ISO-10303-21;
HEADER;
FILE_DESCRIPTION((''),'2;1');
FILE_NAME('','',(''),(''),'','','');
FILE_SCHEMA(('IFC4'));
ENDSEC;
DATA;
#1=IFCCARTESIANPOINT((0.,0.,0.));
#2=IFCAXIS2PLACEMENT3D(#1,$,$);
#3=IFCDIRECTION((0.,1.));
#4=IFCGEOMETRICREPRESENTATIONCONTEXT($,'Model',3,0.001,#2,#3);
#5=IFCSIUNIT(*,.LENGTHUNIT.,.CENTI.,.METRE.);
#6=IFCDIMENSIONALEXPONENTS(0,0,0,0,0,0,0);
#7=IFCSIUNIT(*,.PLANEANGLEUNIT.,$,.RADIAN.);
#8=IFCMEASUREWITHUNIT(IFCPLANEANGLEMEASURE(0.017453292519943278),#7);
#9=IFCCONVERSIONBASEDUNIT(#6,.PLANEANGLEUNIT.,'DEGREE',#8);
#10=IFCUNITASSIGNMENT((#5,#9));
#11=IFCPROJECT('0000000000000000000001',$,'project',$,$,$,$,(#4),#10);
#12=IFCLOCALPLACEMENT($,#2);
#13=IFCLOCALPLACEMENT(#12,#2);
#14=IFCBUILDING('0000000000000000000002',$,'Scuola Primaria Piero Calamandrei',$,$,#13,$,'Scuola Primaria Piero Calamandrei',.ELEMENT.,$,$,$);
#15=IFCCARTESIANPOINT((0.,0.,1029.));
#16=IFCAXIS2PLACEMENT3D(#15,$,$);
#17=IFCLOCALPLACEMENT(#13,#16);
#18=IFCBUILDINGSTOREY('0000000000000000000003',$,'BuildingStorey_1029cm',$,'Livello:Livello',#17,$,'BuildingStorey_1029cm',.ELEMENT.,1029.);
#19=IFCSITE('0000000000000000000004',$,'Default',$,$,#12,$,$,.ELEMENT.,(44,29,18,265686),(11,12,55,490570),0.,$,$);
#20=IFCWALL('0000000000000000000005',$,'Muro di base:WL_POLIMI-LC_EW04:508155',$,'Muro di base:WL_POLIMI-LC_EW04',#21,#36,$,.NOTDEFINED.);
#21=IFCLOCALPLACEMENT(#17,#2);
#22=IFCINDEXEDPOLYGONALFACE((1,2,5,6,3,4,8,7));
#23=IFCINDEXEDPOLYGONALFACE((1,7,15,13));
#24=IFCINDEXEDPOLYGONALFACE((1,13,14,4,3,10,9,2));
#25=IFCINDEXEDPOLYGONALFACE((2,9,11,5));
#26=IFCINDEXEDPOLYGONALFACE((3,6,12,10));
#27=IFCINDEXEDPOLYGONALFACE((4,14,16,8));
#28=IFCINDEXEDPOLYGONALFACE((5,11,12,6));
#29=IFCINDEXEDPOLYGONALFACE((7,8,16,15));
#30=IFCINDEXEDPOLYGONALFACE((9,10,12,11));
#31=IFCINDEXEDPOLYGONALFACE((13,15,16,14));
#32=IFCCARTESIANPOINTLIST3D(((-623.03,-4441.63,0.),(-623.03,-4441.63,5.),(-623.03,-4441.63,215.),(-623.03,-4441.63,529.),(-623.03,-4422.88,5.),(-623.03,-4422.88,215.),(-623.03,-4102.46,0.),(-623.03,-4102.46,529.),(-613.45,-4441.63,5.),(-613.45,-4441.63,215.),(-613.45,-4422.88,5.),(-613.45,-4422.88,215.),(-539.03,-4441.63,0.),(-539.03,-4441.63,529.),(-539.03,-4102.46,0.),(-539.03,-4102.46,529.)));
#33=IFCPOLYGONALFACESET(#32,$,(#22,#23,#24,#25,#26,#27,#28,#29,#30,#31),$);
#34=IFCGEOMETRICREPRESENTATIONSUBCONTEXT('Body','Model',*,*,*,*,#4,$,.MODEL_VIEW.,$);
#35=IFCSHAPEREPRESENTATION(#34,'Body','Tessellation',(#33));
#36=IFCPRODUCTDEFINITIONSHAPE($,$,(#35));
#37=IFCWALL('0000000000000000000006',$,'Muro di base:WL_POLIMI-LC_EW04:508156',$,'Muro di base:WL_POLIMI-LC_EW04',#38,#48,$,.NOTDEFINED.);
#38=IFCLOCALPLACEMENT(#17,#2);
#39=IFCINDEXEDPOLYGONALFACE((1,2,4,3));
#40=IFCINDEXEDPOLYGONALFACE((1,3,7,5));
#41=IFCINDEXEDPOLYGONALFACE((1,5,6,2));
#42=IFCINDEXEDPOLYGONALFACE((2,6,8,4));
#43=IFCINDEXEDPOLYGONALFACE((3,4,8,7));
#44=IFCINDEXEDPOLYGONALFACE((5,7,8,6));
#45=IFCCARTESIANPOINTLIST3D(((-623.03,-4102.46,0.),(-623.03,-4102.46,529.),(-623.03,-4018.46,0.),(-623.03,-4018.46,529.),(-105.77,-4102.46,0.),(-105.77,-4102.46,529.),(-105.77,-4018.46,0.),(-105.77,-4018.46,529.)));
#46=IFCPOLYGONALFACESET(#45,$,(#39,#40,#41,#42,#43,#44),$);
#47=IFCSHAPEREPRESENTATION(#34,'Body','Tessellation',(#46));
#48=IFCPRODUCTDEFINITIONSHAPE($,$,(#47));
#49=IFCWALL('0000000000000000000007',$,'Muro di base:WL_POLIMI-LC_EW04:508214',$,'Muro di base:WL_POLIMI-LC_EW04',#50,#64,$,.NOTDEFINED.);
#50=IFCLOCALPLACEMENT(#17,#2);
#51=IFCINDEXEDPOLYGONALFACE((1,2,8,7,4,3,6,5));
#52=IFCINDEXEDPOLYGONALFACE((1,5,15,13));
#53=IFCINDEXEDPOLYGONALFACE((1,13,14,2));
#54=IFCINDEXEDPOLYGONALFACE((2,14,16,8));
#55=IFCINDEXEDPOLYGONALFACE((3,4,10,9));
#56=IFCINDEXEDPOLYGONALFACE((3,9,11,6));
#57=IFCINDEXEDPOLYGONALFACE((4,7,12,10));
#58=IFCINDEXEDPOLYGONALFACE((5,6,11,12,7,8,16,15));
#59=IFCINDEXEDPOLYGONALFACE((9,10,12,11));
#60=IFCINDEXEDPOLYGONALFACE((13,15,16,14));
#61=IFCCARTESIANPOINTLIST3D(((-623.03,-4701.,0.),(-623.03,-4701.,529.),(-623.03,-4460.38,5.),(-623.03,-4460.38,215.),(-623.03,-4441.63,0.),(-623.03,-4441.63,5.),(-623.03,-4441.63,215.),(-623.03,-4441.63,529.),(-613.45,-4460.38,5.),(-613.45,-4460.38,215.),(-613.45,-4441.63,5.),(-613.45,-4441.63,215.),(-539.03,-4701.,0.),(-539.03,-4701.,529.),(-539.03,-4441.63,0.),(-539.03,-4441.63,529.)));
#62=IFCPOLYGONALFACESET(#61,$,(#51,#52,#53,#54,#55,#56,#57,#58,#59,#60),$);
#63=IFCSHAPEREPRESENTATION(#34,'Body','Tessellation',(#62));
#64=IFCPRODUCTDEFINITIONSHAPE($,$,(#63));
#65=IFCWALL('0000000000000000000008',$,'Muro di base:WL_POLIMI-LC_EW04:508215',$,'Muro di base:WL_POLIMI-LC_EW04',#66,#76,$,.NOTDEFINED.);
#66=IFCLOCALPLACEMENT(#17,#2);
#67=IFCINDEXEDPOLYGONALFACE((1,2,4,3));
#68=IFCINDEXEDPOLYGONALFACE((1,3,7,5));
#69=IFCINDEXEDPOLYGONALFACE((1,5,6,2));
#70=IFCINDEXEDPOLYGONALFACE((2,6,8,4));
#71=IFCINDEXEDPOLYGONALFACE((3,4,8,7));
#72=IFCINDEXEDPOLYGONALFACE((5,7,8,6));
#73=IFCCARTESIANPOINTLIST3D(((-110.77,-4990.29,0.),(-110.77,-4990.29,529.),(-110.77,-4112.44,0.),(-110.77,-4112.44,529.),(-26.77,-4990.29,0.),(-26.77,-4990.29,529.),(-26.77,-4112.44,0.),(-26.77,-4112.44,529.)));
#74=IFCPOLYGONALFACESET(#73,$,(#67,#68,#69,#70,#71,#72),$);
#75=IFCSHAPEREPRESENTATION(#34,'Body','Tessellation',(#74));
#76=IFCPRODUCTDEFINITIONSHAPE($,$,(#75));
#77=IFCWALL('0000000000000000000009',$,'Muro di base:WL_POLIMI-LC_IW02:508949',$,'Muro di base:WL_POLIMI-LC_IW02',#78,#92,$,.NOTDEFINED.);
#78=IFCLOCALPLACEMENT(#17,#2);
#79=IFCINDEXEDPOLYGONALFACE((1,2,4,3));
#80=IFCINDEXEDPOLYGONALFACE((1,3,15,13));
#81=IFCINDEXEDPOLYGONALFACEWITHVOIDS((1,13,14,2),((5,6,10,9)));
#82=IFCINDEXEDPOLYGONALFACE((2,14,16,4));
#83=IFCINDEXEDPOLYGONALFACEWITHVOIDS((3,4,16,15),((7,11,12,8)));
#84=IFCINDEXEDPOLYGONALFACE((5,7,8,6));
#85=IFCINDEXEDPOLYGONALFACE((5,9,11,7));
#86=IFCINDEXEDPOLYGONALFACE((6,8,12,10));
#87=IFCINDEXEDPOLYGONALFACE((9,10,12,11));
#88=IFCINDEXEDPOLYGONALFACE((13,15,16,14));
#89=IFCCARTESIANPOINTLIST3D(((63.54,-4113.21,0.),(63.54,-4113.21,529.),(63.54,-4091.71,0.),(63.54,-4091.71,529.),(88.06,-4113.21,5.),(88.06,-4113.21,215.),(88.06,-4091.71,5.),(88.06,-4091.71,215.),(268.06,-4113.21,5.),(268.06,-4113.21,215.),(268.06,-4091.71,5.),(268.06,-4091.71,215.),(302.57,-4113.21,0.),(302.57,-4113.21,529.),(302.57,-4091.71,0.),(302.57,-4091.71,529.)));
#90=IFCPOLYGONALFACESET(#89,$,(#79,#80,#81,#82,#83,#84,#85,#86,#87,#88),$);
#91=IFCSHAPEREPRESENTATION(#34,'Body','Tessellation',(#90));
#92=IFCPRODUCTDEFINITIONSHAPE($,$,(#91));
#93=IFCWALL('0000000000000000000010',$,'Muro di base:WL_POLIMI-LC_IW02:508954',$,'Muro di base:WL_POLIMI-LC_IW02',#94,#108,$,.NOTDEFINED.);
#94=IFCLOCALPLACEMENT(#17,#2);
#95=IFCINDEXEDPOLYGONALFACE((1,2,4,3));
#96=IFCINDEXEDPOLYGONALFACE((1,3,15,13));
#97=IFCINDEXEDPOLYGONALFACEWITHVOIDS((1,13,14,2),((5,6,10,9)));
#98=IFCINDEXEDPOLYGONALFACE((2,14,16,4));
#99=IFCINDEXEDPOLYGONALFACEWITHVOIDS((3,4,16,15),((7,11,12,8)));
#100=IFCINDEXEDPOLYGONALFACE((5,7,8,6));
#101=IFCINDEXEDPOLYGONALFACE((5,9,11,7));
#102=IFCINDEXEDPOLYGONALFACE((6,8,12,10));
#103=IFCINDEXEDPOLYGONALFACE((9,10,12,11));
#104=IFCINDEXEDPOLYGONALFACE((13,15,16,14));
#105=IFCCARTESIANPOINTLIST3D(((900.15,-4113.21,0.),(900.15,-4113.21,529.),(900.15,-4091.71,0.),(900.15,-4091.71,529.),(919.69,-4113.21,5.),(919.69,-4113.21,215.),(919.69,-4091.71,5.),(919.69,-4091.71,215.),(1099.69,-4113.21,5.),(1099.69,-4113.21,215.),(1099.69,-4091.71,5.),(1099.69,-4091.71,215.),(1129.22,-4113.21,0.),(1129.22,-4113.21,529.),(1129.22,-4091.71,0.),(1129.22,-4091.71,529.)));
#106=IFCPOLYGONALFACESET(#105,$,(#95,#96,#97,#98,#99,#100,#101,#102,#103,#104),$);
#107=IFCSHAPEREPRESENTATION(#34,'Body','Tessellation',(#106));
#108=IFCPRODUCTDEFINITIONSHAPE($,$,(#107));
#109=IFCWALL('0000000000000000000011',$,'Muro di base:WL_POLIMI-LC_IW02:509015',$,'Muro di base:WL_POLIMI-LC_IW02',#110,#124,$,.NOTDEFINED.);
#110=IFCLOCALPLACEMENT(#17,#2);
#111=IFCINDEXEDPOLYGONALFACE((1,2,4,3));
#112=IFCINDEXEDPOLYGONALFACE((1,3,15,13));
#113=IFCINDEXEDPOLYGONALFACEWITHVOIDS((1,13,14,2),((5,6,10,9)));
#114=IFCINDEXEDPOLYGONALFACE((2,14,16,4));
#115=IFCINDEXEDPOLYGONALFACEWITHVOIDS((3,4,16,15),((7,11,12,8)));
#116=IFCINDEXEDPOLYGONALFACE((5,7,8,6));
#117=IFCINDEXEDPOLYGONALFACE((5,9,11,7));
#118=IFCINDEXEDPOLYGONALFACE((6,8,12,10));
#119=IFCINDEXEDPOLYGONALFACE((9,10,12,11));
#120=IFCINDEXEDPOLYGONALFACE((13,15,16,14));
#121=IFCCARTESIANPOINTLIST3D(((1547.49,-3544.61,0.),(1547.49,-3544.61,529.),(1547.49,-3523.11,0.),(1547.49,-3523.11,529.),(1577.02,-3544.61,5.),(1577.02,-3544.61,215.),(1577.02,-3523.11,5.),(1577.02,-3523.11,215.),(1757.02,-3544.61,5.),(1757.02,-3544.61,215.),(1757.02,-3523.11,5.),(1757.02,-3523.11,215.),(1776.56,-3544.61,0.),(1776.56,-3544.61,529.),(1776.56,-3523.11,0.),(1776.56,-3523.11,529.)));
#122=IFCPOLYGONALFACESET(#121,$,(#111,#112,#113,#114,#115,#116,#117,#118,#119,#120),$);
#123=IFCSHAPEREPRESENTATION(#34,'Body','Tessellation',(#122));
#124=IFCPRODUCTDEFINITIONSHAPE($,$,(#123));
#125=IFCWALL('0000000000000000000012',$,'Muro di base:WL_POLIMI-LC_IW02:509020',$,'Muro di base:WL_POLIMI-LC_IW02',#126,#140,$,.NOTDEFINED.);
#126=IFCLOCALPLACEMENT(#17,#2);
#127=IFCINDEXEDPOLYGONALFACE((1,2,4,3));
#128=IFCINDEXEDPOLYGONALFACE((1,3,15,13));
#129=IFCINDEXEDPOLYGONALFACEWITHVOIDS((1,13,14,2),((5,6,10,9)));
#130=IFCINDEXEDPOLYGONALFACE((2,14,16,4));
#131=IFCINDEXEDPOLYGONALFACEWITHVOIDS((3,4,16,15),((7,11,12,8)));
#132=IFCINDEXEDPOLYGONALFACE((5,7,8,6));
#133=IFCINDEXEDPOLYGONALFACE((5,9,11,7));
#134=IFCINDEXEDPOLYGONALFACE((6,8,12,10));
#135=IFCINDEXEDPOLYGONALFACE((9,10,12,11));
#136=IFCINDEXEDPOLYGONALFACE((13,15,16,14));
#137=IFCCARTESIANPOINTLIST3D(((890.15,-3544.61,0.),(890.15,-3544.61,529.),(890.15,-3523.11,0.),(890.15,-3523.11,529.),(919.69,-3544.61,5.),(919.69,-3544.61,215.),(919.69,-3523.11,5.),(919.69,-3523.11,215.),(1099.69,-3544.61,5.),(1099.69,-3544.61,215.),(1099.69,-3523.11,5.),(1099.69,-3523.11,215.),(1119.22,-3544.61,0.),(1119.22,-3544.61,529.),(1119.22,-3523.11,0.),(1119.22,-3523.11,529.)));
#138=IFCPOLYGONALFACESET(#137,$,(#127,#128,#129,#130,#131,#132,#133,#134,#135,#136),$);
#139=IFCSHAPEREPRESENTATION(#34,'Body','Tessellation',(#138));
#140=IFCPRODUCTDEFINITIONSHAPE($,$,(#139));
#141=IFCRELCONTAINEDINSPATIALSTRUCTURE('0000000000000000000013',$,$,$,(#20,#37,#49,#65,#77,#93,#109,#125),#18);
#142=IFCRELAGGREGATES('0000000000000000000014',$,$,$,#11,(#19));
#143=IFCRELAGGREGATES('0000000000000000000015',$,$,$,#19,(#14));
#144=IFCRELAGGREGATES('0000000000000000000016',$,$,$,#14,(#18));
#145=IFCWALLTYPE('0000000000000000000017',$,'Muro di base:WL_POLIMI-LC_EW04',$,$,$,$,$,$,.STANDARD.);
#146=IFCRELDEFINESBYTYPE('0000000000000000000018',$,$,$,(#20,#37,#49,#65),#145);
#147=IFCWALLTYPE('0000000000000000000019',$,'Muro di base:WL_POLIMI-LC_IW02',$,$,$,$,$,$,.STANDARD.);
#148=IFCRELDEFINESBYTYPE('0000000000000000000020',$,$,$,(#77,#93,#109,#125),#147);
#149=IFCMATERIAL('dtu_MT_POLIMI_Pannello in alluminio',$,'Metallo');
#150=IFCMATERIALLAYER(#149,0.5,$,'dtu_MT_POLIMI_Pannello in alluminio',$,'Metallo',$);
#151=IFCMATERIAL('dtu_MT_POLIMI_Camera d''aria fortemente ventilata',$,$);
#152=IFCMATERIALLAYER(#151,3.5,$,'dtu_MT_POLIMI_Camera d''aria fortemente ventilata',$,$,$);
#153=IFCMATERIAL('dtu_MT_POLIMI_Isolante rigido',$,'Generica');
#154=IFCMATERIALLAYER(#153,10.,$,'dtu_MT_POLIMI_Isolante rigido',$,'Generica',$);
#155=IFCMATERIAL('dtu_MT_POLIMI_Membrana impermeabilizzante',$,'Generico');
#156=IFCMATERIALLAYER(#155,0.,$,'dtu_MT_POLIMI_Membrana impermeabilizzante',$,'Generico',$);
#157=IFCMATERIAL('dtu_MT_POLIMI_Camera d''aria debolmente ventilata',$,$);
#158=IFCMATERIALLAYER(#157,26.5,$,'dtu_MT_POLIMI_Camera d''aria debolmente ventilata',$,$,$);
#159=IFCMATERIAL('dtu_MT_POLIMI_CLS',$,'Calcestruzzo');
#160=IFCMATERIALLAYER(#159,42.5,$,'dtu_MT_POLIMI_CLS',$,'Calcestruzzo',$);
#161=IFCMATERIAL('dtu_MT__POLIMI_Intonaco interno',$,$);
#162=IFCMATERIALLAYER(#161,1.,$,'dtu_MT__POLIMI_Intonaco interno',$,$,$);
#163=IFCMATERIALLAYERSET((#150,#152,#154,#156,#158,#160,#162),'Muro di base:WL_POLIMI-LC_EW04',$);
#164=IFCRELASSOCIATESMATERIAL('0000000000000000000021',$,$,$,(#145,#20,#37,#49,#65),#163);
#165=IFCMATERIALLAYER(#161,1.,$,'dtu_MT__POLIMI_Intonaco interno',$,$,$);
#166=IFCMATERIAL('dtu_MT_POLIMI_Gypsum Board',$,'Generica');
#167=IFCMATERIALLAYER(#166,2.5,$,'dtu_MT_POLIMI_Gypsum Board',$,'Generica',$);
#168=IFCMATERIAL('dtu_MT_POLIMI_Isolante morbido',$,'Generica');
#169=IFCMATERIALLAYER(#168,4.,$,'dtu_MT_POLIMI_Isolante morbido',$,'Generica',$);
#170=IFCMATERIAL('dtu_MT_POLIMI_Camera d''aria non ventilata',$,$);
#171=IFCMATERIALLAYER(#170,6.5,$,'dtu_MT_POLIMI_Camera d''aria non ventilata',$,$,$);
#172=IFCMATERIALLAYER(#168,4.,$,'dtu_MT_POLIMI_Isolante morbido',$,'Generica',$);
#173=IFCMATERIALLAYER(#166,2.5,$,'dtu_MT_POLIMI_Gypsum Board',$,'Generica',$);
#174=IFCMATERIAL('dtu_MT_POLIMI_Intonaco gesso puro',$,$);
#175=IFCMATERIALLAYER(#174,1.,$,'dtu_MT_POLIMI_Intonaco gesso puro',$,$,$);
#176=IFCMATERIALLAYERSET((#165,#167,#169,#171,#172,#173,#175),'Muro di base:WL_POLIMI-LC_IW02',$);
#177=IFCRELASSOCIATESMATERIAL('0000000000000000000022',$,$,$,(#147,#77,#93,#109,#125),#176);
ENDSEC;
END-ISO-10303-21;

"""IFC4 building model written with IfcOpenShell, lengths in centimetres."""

from ifc_helpers import new_model, entity, si_unit, converted_unit, direction, frame, frame_2d, origin, place, context, subcontext, project, spatial, rectangle, extrude, material, layer, layer_set, layer_usage, type_object, element, save


model = new_model("IFC4")

# Units and contexts
model_context = context("Model", 3, precision=0.001, world=origin(), true_north=direction((0.0, 1.0)))
body_context = subcontext(model_context, "Body", "Model", "MODEL_VIEW")
ifc_project = project(units=[si_unit("LENGTHUNIT", "METRE", prefix="CENTI"), converted_unit("PLANEANGLEUNIT", "DEGREE", entity("IfcPlaneAngleMeasure", 0.017453292519943278), si_unit("PLANEANGLEUNIT", "RADIAN"), dimensions=[0, 0, 0, 0, 0, 0, 0])], contexts=[model_context])

# Site, building, storey
site_placement = place(None, origin())
site = spatial("IfcSite", under=ifc_project, at=site_placement, Name="Default", CompositionType="ELEMENT", RefLatitude=(44, 29, 18, 265686), RefLongitude=(11, 12, 55, 490570), RefElevation=0.0)
building_placement = place(site_placement, origin())
building = spatial("IfcBuilding", under=site, at=building_placement, Name="Scuola Primaria Piero Calamandrei", LongName="Scuola Primaria Piero Calamandrei", CompositionType="ELEMENT")
storey_placement = place(building_placement, frame((0.0, 0.0, 1029.0)))
storey = spatial("IfcBuildingStorey", under=building, at=storey_placement, Name="BuildingStorey_1029cm", ObjectType="Livello:Livello", LongName="BuildingStorey_1029cm", CompositionType="ELEMENT", Elevation=1029.0)

# Wall, opening
ifc_material_1 = material(Name="dtu_MT_POLIMI_Pannello in alluminio", Category="Metallo")
ifc_layer_1 = layer(ifc_material_1, 0.5, Name="dtu_MT_POLIMI_Pannello in alluminio", Category="Metallo")
ifc_material_2 = material(Name="dtu_MT_POLIMI_Camera d'aria fortemente ventilata")
ifc_layer_2 = layer(ifc_material_2, 3.5, Name="dtu_MT_POLIMI_Camera d'aria fortemente ventilata")
ifc_material_3 = material(Name="dtu_MT_POLIMI_Isolante rigido", Category="Generica")
ifc_layer_3 = layer(ifc_material_3, 10.0, Name="dtu_MT_POLIMI_Isolante rigido", Category="Generica")
ifc_material_4 = material(Name="dtu_MT_POLIMI_Membrana impermeabilizzante", Category="Generico")
ifc_layer_4 = layer(ifc_material_4, 0.0, Name="dtu_MT_POLIMI_Membrana impermeabilizzante", Category="Generico")
ifc_material_5 = material(Name="dtu_MT_POLIMI_Camera d'aria debolmente ventilata")
ifc_layer_5 = layer(ifc_material_5, 26.5, Name="dtu_MT_POLIMI_Camera d'aria debolmente ventilata")
ifc_material_6 = material(Name="dtu_MT_POLIMI_CLS", Category="Calcestruzzo")
ifc_layer_6 = layer(ifc_material_6, 42.5, Name="dtu_MT_POLIMI_CLS", Category="Calcestruzzo")
ifc_material_7 = material(Name="dtu_MT__POLIMI_Intonaco interno")
ifc_layer_7 = layer(ifc_material_7, 1.0, Name="dtu_MT__POLIMI_Intonaco interno")
ifc_layer_set_1 = layer_set([ifc_layer_1, ifc_layer_2, ifc_layer_3, ifc_layer_4, ifc_layer_5, ifc_layer_6, ifc_layer_7], Name="Muro di base:WL_POLIMI-LC_EW04")
ifc_layer_usage_1 = layer_usage(ifc_layer_set_1, "AXIS2", "NEGATIVE", 42.0)
wall_type_1 = type_object("IfcWallType", Name="Muro di base:WL_POLIMI-LC_EW04", PredefinedType="STANDARD", material=ifc_layer_set_1)
wall_1_placement = place(storey_placement, frame((-581.03, -4102.46, 0.0), z_axis=(0.0, 0.0, 1.0), x_axis=(0.0, -1.0, 0.0)))
wall_1 = element("IfcWall", 1, at=wall_1_placement, inside=storey, type_object=wall_type_1, material=ifc_layer_usage_1, Name="Muro di base:WL_POLIMI-LC_EW04:508155", ObjectType="Muro di base:WL_POLIMI-LC_EW04", PredefinedType="NOTDEFINED", context=body_context, shape_type="SweptSolid", body=[
    extrude(rectangle(XDim=339.17, YDim=84.0, at=frame_2d((169.58, 0.0), x_axis=(-1.0, 0.0))), origin(), (0.0, 0.0, 1.0), 529.0),
])
opening_1_placement = place(wall_1_placement, frame((-4102.46, 581.03, 5.0)))
element("IfcOpeningElement", 2, at=opening_1_placement, cuts=wall_1, PredefinedType="OPENING", context=body_context, shape_type="SweptSolid", body=[
    extrude(rectangle(XDim=210.0, YDim=37.5, at=frame_2d((0.0, 0.0), x_axis=(0.0, 1.0))), frame((4441.63, -753.45, 105.0), z_axis=(0.0, 1.0, 0.0), x_axis=(1.0, 0.0, 0.0)), (0.0, 0.0, 1.0), 140.0),
])

# Wall
ifc_layer_usage_2 = layer_usage(ifc_layer_set_1, "AXIS2", "NEGATIVE", 42.0)
wall_2_placement = place(storey_placement, frame((-105.77, -4060.46, 0.0), z_axis=(0.0, 0.0, 1.0), x_axis=(-1.0, 0.0, 0.0)))
element("IfcWall", 3, at=wall_2_placement, inside=storey, type_object=wall_type_1, material=ifc_layer_usage_2, Name="Muro di base:WL_POLIMI-LC_EW04:508156", ObjectType="Muro di base:WL_POLIMI-LC_EW04", PredefinedType="NOTDEFINED", context=body_context, shape_type="SweptSolid", body=[
    extrude(rectangle(XDim=517.26, YDim=84.0, at=frame_2d((258.63, 0.0), x_axis=(-1.0, 0.0))), origin(), (0.0, 0.0, 1.0), 529.0),
])

# Wall, opening
ifc_layer_usage_3 = layer_usage(ifc_layer_set_1, "AXIS2", "NEGATIVE", 42.0)
wall_3_placement = place(storey_placement, frame((-581.03, -4441.63, 0.0), z_axis=(0.0, 0.0, 1.0), x_axis=(0.0, -1.0, 0.0)))
wall_3 = element("IfcWall", 4, at=wall_3_placement, inside=storey, type_object=wall_type_1, material=ifc_layer_usage_3, Name="Muro di base:WL_POLIMI-LC_EW04:508214", ObjectType="Muro di base:WL_POLIMI-LC_EW04", PredefinedType="NOTDEFINED", context=body_context, shape_type="SweptSolid", body=[
    extrude(rectangle(XDim=259.36, YDim=84.0, at=frame_2d((129.68, 0.0), x_axis=(-1.0, 0.0))), origin(), (0.0, 0.0, 1.0), 529.0),
])
opening_2_placement = place(wall_3_placement, frame((-4441.63, 581.03, 5.0)))
element("IfcOpeningElement", 5, at=opening_2_placement, cuts=wall_3, PredefinedType="OPENING", context=body_context, shape_type="SweptSolid", body=[
    extrude(rectangle(XDim=210.0, YDim=37.5, at=frame_2d((0.0, 0.0), x_axis=(0.0, 1.0))), frame((4441.63, -753.45, 105.0), z_axis=(0.0, 1.0, 0.0), x_axis=(1.0, 0.0, 0.0)), (0.0, 0.0, 1.0), 140.0),
])

# Wall
ifc_layer_usage_4 = layer_usage(ifc_layer_set_1, "AXIS2", "NEGATIVE", 42.0)
wall_4_placement = place(storey_placement, frame((-68.77, -4990.29, 0.0), z_axis=(0.0, 0.0, 1.0), x_axis=(0.0, 1.0, 0.0)))
element("IfcWall", 6, at=wall_4_placement, inside=storey, type_object=wall_type_1, material=ifc_layer_usage_4, Name="Muro di base:WL_POLIMI-LC_EW04:508215", ObjectType="Muro di base:WL_POLIMI-LC_EW04", PredefinedType="NOTDEFINED", context=body_context, shape_type="SweptSolid", body=[
    extrude(rectangle(XDim=877.85, YDim=84.0, at=frame_2d((438.92, 0.0), x_axis=(-1.0, 0.0))), origin(), (0.0, 0.0, 1.0), 529.0),
])

# Walls, openings
ifc_layer_8 = layer(ifc_material_7, 1.0, Name="dtu_MT__POLIMI_Intonaco interno")
ifc_material_8 = material(Name="dtu_MT_POLIMI_Gypsum Board", Category="Generica")
ifc_layer_9 = layer(ifc_material_8, 2.5, Name="dtu_MT_POLIMI_Gypsum Board", Category="Generica")
ifc_material_9 = material(Name="dtu_MT_POLIMI_Isolante morbido", Category="Generica")
ifc_layer_10 = layer(ifc_material_9, 4.0, Name="dtu_MT_POLIMI_Isolante morbido", Category="Generica")
ifc_material_10 = material(Name="dtu_MT_POLIMI_Camera d'aria non ventilata")
ifc_layer_11 = layer(ifc_material_10, 6.5, Name="dtu_MT_POLIMI_Camera d'aria non ventilata")
ifc_layer_12 = layer(ifc_material_9, 4.0, Name="dtu_MT_POLIMI_Isolante morbido", Category="Generica")
ifc_layer_13 = layer(ifc_material_8, 2.5, Name="dtu_MT_POLIMI_Gypsum Board", Category="Generica")
ifc_material_11 = material(Name="dtu_MT_POLIMI_Intonaco gesso puro")
ifc_layer_14 = layer(ifc_material_11, 1.0, Name="dtu_MT_POLIMI_Intonaco gesso puro")
ifc_layer_set_2 = layer_set([ifc_layer_8, ifc_layer_9, ifc_layer_10, ifc_layer_11, ifc_layer_12, ifc_layer_13, ifc_layer_14], Name="Muro di base:WL_POLIMI-LC_IW02")
ifc_layer_usage_5 = layer_usage(ifc_layer_set_2, "AXIS2", "NEGATIVE", 10.75)
wall_type_2 = type_object("IfcWallType", Name="Muro di base:WL_POLIMI-LC_IW02", PredefinedType="STANDARD", material=ifc_layer_set_2)
wall_5_placement = place(storey_placement, frame((302.57, -4102.46, 0.0), z_axis=(0.0, 0.0, 1.0), x_axis=(-1.0, 0.0, 0.0)))
wall_5 = element("IfcWall", 7, at=wall_5_placement, inside=storey, type_object=wall_type_2, material=ifc_layer_usage_5, Name="Muro di base:WL_POLIMI-LC_IW02:508949", ObjectType="Muro di base:WL_POLIMI-LC_IW02", PredefinedType="NOTDEFINED", context=body_context, shape_type="SweptSolid", body=[
    extrude(rectangle(XDim=239.03, YDim=21.5, at=frame_2d((119.52, 0.0), x_axis=(-1.0, 0.0))), origin(), (0.0, 0.0, 1.0), 529.0),
])
opening_3_placement = place(wall_5_placement, frame((214.52, 10.75, 5.0)))
element("IfcOpeningElement", 8, at=opening_3_placement, cuts=wall_5, PredefinedType="OPENING", context=body_context, shape_type="SweptSolid", body=[
    extrude(rectangle(XDim=210.0, YDim=180.0, at=frame_2d((105.0, 90.0), x_axis=(-1.0, 0.0))), frame((0.0, 0.0, 0.0), z_axis=(0.0, -1.0, 0.0), x_axis=(0.0, 0.0, 1.0)), (0.0, 0.0, 1.0), 21.5),
])
ifc_layer_usage_6 = layer_usage(ifc_layer_set_2, "AXIS2", "NEGATIVE", 10.75)
wall_6_placement = place(storey_placement, frame((1129.22, -4102.46, 0.0), z_axis=(0.0, 0.0, 1.0), x_axis=(-1.0, 0.0, 0.0)))
wall_6 = element("IfcWall", 9, at=wall_6_placement, inside=storey, type_object=wall_type_2, material=ifc_layer_usage_6, Name="Muro di base:WL_POLIMI-LC_IW02:508954", ObjectType="Muro di base:WL_POLIMI-LC_IW02", PredefinedType="NOTDEFINED", context=body_context, shape_type="SweptSolid", body=[
    extrude(rectangle(XDim=229.07, YDim=21.5, at=frame_2d((114.54, 0.0), x_axis=(-1.0, 0.0))), origin(), (0.0, 0.0, 1.0), 529.0),
])
opening_4_placement = place(wall_6_placement, frame((209.54, 10.75, 5.0)))
element("IfcOpeningElement", 10, at=opening_4_placement, cuts=wall_6, PredefinedType="OPENING", context=body_context, shape_type="SweptSolid", body=[
    extrude(rectangle(XDim=210.0, YDim=180.0, at=frame_2d((105.0, 90.0), x_axis=(-1.0, 0.0))), frame((0.0, 0.0, 0.0), z_axis=(0.0, -1.0, 0.0), x_axis=(0.0, 0.0, 1.0)), (0.0, 0.0, 1.0), 21.5),
])
ifc_layer_usage_7 = layer_usage(ifc_layer_set_2, "AXIS2", "NEGATIVE", 10.75)
wall_7_placement = place(storey_placement, frame((1547.49, -3533.86, 0.0)))
wall_7 = element("IfcWall", 11, at=wall_7_placement, inside=storey, type_object=wall_type_2, material=ifc_layer_usage_7, Name="Muro di base:WL_POLIMI-LC_IW02:509015", ObjectType="Muro di base:WL_POLIMI-LC_IW02", PredefinedType="NOTDEFINED", context=body_context, shape_type="SweptSolid", body=[
    extrude(rectangle(XDim=229.07, YDim=21.5, at=frame_2d((114.54, 0.0), x_axis=(-1.0, 0.0))), origin(), (0.0, 0.0, 1.0), 529.0),
])
opening_5_placement = place(wall_7_placement, frame((209.54, 10.75, 5.0)))
element("IfcOpeningElement", 12, at=opening_5_placement, cuts=wall_7, PredefinedType="OPENING", context=body_context, shape_type="SweptSolid", body=[
    extrude(rectangle(XDim=210.0, YDim=180.0, at=frame_2d((105.0, 90.0), x_axis=(-1.0, 0.0))), frame((0.0, 0.0, 0.0), z_axis=(0.0, -1.0, 0.0), x_axis=(0.0, 0.0, 1.0)), (0.0, 0.0, 1.0), 21.5),
])
ifc_layer_usage_8 = layer_usage(ifc_layer_set_2, "AXIS2", "NEGATIVE", 10.75)
wall_8_placement = place(storey_placement, frame((890.15, -3533.86, 0.0)))
wall_8 = element("IfcWall", 13, at=wall_8_placement, inside=storey, type_object=wall_type_2, material=ifc_layer_usage_8, Name="Muro di base:WL_POLIMI-LC_IW02:509020", ObjectType="Muro di base:WL_POLIMI-LC_IW02", PredefinedType="NOTDEFINED", context=body_context, shape_type="SweptSolid", body=[
    extrude(rectangle(XDim=229.07, YDim=21.5, at=frame_2d((114.54, 0.0), x_axis=(-1.0, 0.0))), origin(), (0.0, 0.0, 1.0), 529.0),
])
opening_6_placement = place(wall_8_placement, frame((209.54, 10.75, 5.0)))
element("IfcOpeningElement", 14, at=opening_6_placement, cuts=wall_8, PredefinedType="OPENING", context=body_context, shape_type="SweptSolid", body=[
    extrude(rectangle(XDim=210.0, YDim=180.0, at=frame_2d((105.0, 90.0), x_axis=(-1.0, 0.0))), frame((0.0, 0.0, 0.0), z_axis=(0.0, -1.0, 0.0), x_axis=(0.0, 0.0, 1.0)), (0.0, 0.0, 1.0), 21.5),
])

save(model, "model.ifc")
